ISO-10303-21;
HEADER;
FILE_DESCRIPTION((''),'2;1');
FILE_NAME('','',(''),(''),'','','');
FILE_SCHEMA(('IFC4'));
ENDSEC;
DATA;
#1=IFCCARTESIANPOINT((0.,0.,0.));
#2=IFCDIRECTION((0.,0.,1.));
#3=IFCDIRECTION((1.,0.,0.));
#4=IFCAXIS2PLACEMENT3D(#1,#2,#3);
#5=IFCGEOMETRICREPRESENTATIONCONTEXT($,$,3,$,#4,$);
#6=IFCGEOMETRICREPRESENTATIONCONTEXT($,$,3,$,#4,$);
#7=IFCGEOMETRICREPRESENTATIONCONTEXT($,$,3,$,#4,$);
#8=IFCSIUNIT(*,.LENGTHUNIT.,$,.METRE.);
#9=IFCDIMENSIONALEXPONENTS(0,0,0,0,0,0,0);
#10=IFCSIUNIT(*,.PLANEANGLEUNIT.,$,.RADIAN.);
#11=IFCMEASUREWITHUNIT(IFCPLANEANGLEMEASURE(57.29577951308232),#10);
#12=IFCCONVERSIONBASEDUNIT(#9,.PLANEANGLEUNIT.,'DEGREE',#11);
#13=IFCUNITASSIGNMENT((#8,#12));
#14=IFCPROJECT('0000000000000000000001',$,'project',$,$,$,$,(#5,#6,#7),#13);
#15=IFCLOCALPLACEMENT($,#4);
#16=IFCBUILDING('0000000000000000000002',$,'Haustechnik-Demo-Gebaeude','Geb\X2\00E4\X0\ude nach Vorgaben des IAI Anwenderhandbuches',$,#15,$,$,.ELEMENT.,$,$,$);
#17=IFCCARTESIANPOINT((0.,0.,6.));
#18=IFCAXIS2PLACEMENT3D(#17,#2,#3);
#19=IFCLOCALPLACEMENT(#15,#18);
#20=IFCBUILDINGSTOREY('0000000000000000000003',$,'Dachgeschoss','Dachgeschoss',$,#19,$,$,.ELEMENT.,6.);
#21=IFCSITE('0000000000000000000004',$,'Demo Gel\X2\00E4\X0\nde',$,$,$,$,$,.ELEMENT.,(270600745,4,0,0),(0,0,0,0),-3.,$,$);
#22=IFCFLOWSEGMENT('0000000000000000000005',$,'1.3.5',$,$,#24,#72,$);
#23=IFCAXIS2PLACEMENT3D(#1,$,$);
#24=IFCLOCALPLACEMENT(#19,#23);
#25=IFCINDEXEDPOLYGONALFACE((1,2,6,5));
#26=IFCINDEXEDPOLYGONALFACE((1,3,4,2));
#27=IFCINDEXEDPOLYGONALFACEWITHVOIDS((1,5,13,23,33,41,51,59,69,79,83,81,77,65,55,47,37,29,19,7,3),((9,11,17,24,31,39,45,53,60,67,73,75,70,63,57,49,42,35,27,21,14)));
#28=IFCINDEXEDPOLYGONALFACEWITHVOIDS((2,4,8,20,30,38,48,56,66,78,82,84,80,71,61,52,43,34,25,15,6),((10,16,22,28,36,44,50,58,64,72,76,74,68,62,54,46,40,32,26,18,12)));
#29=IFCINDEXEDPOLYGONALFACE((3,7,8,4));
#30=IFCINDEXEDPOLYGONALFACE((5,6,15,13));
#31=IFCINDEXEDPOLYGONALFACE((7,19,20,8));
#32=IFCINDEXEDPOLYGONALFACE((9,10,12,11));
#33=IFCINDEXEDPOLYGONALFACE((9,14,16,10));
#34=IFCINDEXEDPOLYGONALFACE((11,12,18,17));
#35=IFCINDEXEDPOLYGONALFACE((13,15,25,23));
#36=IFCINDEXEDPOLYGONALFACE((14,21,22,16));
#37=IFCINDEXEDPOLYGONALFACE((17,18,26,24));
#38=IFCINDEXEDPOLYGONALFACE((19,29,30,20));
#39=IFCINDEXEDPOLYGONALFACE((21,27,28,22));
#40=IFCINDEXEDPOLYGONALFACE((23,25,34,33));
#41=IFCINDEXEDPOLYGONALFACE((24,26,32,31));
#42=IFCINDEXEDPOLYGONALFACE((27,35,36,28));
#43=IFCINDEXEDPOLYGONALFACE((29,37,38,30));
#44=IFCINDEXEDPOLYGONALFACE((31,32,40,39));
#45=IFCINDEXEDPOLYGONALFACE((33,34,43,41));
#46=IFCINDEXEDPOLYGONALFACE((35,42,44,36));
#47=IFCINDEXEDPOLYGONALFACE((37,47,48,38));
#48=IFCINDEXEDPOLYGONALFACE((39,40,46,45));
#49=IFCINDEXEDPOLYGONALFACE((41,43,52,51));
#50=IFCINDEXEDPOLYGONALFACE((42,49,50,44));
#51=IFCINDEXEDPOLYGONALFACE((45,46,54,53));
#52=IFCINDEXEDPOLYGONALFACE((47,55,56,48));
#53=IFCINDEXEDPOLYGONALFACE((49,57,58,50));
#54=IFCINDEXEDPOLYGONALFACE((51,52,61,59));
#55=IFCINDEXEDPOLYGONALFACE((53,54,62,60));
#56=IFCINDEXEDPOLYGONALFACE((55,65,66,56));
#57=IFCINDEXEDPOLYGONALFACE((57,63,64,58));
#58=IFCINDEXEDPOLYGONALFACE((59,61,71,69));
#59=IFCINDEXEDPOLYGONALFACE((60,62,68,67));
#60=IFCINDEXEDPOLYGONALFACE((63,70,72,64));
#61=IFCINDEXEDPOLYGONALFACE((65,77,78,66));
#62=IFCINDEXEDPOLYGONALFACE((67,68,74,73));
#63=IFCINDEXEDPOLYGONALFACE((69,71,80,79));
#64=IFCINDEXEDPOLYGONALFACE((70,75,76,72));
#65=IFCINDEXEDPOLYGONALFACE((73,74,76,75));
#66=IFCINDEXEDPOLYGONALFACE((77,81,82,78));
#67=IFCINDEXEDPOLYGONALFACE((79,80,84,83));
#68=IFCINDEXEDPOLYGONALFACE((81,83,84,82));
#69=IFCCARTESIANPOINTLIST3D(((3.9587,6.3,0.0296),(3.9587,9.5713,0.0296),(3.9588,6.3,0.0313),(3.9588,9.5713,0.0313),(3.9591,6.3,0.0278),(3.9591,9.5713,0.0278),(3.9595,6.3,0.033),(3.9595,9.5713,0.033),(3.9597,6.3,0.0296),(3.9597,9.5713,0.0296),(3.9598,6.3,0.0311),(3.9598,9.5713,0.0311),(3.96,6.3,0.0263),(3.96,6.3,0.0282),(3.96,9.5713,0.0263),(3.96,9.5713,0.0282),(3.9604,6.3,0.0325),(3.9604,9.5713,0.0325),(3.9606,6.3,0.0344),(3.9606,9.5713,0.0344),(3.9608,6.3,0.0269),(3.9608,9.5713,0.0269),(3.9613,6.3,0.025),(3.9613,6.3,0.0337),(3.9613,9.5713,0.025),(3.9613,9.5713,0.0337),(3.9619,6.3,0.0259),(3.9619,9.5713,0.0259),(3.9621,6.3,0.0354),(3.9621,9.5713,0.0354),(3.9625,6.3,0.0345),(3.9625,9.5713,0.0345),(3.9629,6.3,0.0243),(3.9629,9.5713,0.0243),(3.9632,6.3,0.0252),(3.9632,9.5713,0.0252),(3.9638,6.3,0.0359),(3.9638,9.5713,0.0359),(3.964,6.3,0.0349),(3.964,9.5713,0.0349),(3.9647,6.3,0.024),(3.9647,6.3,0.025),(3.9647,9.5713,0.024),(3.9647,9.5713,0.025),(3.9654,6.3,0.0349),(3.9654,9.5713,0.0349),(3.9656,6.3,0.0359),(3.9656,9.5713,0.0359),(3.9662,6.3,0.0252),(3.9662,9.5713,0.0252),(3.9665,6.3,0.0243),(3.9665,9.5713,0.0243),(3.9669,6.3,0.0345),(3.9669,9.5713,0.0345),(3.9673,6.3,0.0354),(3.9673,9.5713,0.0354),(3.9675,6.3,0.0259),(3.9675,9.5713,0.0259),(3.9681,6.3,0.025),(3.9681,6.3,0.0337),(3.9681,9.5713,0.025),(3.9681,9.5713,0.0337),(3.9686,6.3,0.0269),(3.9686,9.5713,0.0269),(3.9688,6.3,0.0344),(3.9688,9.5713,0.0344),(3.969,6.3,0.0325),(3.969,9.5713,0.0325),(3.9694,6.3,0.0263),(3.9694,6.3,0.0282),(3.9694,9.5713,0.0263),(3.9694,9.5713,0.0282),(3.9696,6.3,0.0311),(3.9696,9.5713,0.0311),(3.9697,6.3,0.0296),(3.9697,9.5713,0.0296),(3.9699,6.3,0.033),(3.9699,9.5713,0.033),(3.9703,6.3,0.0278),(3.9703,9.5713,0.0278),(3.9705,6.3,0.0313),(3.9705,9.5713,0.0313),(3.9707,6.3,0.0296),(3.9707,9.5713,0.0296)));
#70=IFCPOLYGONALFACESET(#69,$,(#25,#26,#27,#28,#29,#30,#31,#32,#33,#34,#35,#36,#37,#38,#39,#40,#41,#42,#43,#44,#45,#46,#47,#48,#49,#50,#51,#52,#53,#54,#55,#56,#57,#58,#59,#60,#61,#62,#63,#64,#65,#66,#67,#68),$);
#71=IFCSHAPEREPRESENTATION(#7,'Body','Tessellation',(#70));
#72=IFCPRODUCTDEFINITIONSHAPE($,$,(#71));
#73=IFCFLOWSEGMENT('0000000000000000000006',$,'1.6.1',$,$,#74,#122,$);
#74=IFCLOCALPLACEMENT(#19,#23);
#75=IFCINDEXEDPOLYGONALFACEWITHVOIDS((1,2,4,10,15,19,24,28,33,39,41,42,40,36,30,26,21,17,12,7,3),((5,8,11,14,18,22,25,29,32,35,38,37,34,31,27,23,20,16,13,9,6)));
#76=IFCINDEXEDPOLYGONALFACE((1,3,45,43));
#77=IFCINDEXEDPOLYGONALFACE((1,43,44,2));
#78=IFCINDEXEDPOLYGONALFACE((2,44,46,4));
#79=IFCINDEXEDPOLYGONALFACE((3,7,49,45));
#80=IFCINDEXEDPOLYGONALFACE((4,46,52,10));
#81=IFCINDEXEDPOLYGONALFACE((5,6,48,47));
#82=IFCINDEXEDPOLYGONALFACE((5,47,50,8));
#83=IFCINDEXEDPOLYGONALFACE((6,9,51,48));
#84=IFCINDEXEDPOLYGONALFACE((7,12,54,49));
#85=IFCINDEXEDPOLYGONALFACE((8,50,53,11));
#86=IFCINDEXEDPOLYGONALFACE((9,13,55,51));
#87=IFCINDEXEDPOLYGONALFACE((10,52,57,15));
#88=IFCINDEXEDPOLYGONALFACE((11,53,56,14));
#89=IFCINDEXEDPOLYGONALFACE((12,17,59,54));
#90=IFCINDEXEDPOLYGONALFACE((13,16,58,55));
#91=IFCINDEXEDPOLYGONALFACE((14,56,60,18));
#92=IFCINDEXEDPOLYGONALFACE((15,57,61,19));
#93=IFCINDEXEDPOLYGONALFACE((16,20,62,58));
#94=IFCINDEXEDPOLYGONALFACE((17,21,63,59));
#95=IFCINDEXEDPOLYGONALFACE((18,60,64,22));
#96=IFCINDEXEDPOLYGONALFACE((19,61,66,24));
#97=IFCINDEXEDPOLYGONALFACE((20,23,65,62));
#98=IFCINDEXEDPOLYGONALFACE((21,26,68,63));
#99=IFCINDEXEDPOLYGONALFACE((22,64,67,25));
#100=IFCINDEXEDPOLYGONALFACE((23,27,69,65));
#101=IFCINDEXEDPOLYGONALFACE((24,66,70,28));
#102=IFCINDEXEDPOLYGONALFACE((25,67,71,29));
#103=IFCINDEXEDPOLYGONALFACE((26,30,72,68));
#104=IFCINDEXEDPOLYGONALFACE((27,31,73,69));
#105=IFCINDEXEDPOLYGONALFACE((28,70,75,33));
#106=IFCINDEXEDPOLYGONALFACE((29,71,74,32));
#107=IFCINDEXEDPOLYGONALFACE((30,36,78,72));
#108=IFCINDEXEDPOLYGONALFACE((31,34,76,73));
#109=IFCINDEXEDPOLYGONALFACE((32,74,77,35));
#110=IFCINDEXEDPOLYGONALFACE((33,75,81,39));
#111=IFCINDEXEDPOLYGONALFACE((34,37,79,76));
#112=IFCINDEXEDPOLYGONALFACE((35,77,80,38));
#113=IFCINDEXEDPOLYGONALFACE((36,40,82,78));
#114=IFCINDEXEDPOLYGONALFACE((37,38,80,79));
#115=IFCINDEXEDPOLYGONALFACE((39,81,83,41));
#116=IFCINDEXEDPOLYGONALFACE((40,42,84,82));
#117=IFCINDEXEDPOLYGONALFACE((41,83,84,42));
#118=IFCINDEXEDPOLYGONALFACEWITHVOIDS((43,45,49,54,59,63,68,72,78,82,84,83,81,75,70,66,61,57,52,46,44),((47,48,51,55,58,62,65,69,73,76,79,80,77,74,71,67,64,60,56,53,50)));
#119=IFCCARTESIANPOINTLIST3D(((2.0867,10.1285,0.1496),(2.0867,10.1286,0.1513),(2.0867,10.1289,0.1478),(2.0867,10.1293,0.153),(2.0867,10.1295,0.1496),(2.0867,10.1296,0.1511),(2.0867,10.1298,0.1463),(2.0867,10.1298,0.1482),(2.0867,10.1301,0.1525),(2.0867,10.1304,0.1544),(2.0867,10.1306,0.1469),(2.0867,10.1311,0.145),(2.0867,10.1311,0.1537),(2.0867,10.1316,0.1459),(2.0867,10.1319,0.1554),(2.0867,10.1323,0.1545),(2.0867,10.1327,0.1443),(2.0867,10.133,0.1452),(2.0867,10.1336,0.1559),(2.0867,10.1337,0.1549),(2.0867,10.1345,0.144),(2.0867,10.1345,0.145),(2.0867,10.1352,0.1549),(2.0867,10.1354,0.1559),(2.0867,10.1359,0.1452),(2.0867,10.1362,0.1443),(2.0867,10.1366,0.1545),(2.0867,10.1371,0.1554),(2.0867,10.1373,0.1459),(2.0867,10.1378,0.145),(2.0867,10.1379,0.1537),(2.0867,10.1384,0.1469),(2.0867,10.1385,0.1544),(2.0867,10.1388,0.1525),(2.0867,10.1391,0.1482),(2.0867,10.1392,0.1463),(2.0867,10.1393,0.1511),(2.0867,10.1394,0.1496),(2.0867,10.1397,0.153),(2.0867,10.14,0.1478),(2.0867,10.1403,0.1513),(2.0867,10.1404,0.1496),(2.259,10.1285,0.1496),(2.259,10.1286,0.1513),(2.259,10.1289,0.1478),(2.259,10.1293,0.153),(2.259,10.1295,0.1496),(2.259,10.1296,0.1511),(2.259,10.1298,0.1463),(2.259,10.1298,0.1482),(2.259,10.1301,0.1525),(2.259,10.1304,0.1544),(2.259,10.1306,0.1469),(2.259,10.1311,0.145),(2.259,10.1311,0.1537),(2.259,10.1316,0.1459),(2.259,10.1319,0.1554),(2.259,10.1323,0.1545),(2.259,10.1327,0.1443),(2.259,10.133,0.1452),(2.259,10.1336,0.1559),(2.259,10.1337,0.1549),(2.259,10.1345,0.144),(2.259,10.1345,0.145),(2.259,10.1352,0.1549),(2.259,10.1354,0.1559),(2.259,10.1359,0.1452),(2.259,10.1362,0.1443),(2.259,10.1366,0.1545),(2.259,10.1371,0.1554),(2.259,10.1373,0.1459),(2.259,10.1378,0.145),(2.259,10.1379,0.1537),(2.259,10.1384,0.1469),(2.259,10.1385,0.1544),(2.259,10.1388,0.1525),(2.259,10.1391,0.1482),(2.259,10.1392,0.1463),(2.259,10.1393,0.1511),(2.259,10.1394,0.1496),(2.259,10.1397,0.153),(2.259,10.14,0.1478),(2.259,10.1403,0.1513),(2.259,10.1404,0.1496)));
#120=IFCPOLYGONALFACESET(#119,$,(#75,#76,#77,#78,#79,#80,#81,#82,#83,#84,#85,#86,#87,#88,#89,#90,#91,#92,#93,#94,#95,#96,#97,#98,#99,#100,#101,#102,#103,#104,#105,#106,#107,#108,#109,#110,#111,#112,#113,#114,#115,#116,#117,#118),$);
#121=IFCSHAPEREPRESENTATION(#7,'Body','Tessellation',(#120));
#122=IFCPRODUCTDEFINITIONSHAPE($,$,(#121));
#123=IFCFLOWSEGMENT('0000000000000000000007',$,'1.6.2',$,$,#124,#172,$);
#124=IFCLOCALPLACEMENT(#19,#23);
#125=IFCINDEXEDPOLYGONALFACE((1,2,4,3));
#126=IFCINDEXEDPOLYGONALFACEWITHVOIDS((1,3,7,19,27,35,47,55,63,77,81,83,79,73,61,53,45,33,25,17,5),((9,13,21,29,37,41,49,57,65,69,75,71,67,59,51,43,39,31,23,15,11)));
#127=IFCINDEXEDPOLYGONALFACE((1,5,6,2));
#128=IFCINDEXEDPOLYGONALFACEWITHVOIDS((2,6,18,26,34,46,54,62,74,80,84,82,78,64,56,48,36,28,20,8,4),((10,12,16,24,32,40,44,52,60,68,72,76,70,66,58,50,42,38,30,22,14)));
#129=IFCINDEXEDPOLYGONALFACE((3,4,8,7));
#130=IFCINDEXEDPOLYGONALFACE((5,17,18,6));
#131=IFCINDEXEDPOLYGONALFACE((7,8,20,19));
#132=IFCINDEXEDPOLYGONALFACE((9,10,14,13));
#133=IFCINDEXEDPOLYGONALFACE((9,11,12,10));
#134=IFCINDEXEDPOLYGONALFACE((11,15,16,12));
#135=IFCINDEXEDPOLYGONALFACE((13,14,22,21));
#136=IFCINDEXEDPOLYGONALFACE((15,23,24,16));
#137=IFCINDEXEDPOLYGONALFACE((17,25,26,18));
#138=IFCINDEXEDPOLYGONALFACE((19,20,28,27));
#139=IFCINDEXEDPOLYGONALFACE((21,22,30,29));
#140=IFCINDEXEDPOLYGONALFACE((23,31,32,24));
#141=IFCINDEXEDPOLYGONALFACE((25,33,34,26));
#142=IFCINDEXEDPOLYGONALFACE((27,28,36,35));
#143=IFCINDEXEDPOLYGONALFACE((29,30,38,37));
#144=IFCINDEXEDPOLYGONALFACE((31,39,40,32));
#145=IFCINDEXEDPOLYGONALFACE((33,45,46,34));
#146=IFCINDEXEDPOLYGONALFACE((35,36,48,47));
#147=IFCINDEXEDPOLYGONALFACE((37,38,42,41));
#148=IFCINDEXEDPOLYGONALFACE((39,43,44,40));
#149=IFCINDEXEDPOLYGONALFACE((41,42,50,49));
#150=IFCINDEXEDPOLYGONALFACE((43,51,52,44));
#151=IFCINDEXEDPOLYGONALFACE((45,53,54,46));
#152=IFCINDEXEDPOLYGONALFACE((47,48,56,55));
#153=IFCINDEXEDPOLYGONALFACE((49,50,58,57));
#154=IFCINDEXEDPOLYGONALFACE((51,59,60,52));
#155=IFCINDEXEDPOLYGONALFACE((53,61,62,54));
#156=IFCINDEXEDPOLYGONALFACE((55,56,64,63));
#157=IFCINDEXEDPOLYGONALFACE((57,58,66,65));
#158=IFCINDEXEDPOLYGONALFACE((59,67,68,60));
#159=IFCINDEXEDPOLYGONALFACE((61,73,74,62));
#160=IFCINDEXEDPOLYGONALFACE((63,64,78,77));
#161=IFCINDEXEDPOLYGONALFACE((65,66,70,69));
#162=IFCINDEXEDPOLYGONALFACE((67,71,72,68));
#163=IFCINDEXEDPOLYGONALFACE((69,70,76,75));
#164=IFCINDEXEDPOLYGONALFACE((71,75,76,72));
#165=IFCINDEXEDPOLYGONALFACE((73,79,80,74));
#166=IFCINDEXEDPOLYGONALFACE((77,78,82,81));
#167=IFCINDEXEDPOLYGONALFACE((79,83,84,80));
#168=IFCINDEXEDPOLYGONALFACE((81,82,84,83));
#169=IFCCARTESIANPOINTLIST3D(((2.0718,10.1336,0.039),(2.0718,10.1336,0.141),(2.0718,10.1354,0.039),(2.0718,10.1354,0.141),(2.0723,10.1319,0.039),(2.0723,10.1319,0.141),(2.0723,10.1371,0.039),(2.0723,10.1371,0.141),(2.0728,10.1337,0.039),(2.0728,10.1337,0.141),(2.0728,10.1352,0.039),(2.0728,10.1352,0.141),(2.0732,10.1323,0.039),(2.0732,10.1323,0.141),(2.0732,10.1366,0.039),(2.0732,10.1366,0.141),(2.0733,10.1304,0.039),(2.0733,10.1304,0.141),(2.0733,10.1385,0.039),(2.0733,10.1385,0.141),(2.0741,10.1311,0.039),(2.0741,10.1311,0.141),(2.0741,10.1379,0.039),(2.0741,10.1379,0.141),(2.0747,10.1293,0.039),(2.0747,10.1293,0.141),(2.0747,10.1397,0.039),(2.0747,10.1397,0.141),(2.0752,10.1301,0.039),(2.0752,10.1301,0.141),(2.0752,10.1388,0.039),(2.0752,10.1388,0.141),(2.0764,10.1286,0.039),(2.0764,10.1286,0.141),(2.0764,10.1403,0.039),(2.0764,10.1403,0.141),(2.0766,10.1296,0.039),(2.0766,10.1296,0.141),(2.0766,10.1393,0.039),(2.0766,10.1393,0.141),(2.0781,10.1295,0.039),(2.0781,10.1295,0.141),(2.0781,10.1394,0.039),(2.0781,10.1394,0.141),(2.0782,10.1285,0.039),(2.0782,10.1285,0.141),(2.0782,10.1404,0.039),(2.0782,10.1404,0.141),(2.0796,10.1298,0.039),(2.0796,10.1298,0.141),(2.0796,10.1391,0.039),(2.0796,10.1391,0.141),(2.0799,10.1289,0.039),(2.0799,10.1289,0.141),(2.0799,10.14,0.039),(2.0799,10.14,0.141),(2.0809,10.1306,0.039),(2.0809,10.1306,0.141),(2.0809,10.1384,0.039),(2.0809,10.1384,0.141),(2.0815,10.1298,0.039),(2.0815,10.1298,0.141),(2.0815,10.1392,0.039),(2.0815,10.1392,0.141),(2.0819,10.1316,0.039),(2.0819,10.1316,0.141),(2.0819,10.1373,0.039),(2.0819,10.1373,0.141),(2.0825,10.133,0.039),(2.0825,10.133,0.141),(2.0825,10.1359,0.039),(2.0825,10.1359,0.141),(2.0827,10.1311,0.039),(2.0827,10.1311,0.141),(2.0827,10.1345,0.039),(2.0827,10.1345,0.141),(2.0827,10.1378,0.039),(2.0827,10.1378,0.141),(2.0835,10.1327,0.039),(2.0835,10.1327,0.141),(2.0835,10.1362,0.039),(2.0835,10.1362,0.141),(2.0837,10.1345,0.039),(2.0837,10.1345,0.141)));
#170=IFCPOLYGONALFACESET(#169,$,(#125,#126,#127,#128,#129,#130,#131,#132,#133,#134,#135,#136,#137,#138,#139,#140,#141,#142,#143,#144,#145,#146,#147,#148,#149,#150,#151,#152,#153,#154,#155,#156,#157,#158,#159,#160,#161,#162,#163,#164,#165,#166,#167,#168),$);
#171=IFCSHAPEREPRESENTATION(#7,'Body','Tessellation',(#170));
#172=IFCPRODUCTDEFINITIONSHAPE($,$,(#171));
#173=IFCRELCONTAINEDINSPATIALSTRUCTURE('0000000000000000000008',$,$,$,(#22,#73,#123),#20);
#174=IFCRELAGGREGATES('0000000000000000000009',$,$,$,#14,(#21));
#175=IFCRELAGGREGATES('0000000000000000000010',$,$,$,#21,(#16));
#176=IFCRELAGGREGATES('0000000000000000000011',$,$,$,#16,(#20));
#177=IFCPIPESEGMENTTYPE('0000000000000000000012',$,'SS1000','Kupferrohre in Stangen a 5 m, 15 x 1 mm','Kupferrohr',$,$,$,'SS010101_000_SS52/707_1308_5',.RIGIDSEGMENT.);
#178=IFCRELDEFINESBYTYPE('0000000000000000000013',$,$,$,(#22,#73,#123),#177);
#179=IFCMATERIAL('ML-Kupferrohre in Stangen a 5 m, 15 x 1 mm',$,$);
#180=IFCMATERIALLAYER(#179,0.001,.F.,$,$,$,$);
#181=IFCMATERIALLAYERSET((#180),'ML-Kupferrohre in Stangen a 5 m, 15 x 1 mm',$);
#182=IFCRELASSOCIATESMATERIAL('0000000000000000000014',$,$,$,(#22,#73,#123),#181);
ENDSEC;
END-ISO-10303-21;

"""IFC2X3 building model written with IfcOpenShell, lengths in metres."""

from ifc_helpers import new_model, entity, si_unit, converted_unit, frame, origin_with_axes, origin_2d_with_axis, place, context, project, spatial, hollow_circle, extrude, material, layer, layer_set, layer_usage, type_object, element, save


model = new_model("IFC2X3")

# Units and contexts
context_of_model_1 = context(None, 3, world=origin_with_axes())
context_of_model_2 = context(None, 3, world=origin_with_axes())
context_of_model_3 = context(None, 3, world=origin_with_axes())
ifc_project = project(units=[si_unit("LENGTHUNIT", "METRE"), converted_unit("PLANEANGLEUNIT", "DEGREE", entity("IfcPlaneAngleMeasure", 57.29577951308232), si_unit("PLANEANGLEUNIT", "RADIAN"), dimensions=[0, 0, 0, 0, 0, 0, 0])], contexts=[context_of_model_1, context_of_model_2, context_of_model_3])

# Site, building, storey
site = spatial("IfcSite", under=ifc_project, Name="Demo Gelände", CompositionType="ELEMENT", RefLatitude=(270600745, 4, 0, 0), RefLongitude=(0, 0, 0, 0), RefElevation=-3.0)
building_placement = place(None, origin_with_axes())
building = spatial("IfcBuilding", under=site, at=building_placement, Name="Haustechnik-Demo-Gebaeude", Description="Gebäude nach Vorgaben des IAI Anwenderhandbuches", CompositionType="ELEMENT")
storey_placement = place(building_placement, frame((0.0, 0.0, 6.0), z_axis=(0.0, 0.0, 1.0), x_axis=(1.0, 0.0, 0.0)))
storey = spatial("IfcBuildingStorey", under=building, at=storey_placement, Name="Dachgeschoss", Description="Dachgeschoss", CompositionType="ELEMENT", Elevation=6.0)

# Flow segments
ifc_material = material(Name="ML-Kupferrohre in Stangen a 5 m, 15 x 1 mm")
ifc_layer = layer(ifc_material, 0.001, ventilated=False)
ifc_layer_set = layer_set([ifc_layer], Name="ML-Kupferrohre in Stangen a 5 m, 15 x 1 mm")
ifc_layer_usage = layer_usage(ifc_layer_set, "AXIS2", "POSITIVE", 0.0)
pipe_segment_type_1 = type_object("IfcPipeSegmentType", Name="SS1000", Description="Kupferrohre in Stangen a 5 m, 15 x 1 mm", ApplicableOccurrence="Kupferrohr", ElementType="SS010101_000_SS52/707_1308_5", PredefinedType="RIGIDSEGMENT")
flow_segment_1_placement = place(storey_placement, frame((3.9647, 6.3, 0.03), z_axis=(0.0, 1.0, 0.0), x_axis=(0.0, 0.0, -1.0)))
element("IfcFlowSegment", 1, at=flow_segment_1_placement, inside=storey, type_object=pipe_segment_type_1, material=ifc_layer_usage, Name="1.3.5", context=context_of_model_3, shape_type="SweptSolid", body=[
    extrude(hollow_circle(Radius=0.006, WallThickness=0.001, at=origin_2d_with_axis()), origin_with_axes(), (0.0, 0.0, 1.0), 3.2713),
])
flow_segment_2_placement = place(storey_placement, frame((2.259, 10.1345, 0.15), z_axis=(-1.0, 0.0, 0.0), x_axis=(0.0, 0.0, -1.0)))
element("IfcFlowSegment", 2, at=flow_segment_2_placement, inside=storey, type_object=pipe_segment_type_1, material=ifc_layer_usage, Name="1.6.1", context=context_of_model_3, shape_type="SweptSolid", body=[
    extrude(hollow_circle(Radius=0.006, WallThickness=0.001, at=origin_2d_with_axis()), origin_with_axes(), (0.0, 0.0, 1.0), 0.1723),
])
flow_segment_3_placement = place(storey_placement, frame((2.0777, 10.1345, 0.141), z_axis=(0.0, 0.0, -1.0), x_axis=(1.0, 0.0, 0.0)))
element("IfcFlowSegment", 3, at=flow_segment_3_placement, inside=storey, type_object=pipe_segment_type_1, material=ifc_layer_usage, Name="1.6.2", context=context_of_model_3, shape_type="SweptSolid", body=[
    extrude(hollow_circle(Radius=0.006, WallThickness=0.001, at=origin_2d_with_axis()), origin_with_axes(), (0.0, 0.0, 1.0), 0.102),
])

save(model, "model.ifc")
